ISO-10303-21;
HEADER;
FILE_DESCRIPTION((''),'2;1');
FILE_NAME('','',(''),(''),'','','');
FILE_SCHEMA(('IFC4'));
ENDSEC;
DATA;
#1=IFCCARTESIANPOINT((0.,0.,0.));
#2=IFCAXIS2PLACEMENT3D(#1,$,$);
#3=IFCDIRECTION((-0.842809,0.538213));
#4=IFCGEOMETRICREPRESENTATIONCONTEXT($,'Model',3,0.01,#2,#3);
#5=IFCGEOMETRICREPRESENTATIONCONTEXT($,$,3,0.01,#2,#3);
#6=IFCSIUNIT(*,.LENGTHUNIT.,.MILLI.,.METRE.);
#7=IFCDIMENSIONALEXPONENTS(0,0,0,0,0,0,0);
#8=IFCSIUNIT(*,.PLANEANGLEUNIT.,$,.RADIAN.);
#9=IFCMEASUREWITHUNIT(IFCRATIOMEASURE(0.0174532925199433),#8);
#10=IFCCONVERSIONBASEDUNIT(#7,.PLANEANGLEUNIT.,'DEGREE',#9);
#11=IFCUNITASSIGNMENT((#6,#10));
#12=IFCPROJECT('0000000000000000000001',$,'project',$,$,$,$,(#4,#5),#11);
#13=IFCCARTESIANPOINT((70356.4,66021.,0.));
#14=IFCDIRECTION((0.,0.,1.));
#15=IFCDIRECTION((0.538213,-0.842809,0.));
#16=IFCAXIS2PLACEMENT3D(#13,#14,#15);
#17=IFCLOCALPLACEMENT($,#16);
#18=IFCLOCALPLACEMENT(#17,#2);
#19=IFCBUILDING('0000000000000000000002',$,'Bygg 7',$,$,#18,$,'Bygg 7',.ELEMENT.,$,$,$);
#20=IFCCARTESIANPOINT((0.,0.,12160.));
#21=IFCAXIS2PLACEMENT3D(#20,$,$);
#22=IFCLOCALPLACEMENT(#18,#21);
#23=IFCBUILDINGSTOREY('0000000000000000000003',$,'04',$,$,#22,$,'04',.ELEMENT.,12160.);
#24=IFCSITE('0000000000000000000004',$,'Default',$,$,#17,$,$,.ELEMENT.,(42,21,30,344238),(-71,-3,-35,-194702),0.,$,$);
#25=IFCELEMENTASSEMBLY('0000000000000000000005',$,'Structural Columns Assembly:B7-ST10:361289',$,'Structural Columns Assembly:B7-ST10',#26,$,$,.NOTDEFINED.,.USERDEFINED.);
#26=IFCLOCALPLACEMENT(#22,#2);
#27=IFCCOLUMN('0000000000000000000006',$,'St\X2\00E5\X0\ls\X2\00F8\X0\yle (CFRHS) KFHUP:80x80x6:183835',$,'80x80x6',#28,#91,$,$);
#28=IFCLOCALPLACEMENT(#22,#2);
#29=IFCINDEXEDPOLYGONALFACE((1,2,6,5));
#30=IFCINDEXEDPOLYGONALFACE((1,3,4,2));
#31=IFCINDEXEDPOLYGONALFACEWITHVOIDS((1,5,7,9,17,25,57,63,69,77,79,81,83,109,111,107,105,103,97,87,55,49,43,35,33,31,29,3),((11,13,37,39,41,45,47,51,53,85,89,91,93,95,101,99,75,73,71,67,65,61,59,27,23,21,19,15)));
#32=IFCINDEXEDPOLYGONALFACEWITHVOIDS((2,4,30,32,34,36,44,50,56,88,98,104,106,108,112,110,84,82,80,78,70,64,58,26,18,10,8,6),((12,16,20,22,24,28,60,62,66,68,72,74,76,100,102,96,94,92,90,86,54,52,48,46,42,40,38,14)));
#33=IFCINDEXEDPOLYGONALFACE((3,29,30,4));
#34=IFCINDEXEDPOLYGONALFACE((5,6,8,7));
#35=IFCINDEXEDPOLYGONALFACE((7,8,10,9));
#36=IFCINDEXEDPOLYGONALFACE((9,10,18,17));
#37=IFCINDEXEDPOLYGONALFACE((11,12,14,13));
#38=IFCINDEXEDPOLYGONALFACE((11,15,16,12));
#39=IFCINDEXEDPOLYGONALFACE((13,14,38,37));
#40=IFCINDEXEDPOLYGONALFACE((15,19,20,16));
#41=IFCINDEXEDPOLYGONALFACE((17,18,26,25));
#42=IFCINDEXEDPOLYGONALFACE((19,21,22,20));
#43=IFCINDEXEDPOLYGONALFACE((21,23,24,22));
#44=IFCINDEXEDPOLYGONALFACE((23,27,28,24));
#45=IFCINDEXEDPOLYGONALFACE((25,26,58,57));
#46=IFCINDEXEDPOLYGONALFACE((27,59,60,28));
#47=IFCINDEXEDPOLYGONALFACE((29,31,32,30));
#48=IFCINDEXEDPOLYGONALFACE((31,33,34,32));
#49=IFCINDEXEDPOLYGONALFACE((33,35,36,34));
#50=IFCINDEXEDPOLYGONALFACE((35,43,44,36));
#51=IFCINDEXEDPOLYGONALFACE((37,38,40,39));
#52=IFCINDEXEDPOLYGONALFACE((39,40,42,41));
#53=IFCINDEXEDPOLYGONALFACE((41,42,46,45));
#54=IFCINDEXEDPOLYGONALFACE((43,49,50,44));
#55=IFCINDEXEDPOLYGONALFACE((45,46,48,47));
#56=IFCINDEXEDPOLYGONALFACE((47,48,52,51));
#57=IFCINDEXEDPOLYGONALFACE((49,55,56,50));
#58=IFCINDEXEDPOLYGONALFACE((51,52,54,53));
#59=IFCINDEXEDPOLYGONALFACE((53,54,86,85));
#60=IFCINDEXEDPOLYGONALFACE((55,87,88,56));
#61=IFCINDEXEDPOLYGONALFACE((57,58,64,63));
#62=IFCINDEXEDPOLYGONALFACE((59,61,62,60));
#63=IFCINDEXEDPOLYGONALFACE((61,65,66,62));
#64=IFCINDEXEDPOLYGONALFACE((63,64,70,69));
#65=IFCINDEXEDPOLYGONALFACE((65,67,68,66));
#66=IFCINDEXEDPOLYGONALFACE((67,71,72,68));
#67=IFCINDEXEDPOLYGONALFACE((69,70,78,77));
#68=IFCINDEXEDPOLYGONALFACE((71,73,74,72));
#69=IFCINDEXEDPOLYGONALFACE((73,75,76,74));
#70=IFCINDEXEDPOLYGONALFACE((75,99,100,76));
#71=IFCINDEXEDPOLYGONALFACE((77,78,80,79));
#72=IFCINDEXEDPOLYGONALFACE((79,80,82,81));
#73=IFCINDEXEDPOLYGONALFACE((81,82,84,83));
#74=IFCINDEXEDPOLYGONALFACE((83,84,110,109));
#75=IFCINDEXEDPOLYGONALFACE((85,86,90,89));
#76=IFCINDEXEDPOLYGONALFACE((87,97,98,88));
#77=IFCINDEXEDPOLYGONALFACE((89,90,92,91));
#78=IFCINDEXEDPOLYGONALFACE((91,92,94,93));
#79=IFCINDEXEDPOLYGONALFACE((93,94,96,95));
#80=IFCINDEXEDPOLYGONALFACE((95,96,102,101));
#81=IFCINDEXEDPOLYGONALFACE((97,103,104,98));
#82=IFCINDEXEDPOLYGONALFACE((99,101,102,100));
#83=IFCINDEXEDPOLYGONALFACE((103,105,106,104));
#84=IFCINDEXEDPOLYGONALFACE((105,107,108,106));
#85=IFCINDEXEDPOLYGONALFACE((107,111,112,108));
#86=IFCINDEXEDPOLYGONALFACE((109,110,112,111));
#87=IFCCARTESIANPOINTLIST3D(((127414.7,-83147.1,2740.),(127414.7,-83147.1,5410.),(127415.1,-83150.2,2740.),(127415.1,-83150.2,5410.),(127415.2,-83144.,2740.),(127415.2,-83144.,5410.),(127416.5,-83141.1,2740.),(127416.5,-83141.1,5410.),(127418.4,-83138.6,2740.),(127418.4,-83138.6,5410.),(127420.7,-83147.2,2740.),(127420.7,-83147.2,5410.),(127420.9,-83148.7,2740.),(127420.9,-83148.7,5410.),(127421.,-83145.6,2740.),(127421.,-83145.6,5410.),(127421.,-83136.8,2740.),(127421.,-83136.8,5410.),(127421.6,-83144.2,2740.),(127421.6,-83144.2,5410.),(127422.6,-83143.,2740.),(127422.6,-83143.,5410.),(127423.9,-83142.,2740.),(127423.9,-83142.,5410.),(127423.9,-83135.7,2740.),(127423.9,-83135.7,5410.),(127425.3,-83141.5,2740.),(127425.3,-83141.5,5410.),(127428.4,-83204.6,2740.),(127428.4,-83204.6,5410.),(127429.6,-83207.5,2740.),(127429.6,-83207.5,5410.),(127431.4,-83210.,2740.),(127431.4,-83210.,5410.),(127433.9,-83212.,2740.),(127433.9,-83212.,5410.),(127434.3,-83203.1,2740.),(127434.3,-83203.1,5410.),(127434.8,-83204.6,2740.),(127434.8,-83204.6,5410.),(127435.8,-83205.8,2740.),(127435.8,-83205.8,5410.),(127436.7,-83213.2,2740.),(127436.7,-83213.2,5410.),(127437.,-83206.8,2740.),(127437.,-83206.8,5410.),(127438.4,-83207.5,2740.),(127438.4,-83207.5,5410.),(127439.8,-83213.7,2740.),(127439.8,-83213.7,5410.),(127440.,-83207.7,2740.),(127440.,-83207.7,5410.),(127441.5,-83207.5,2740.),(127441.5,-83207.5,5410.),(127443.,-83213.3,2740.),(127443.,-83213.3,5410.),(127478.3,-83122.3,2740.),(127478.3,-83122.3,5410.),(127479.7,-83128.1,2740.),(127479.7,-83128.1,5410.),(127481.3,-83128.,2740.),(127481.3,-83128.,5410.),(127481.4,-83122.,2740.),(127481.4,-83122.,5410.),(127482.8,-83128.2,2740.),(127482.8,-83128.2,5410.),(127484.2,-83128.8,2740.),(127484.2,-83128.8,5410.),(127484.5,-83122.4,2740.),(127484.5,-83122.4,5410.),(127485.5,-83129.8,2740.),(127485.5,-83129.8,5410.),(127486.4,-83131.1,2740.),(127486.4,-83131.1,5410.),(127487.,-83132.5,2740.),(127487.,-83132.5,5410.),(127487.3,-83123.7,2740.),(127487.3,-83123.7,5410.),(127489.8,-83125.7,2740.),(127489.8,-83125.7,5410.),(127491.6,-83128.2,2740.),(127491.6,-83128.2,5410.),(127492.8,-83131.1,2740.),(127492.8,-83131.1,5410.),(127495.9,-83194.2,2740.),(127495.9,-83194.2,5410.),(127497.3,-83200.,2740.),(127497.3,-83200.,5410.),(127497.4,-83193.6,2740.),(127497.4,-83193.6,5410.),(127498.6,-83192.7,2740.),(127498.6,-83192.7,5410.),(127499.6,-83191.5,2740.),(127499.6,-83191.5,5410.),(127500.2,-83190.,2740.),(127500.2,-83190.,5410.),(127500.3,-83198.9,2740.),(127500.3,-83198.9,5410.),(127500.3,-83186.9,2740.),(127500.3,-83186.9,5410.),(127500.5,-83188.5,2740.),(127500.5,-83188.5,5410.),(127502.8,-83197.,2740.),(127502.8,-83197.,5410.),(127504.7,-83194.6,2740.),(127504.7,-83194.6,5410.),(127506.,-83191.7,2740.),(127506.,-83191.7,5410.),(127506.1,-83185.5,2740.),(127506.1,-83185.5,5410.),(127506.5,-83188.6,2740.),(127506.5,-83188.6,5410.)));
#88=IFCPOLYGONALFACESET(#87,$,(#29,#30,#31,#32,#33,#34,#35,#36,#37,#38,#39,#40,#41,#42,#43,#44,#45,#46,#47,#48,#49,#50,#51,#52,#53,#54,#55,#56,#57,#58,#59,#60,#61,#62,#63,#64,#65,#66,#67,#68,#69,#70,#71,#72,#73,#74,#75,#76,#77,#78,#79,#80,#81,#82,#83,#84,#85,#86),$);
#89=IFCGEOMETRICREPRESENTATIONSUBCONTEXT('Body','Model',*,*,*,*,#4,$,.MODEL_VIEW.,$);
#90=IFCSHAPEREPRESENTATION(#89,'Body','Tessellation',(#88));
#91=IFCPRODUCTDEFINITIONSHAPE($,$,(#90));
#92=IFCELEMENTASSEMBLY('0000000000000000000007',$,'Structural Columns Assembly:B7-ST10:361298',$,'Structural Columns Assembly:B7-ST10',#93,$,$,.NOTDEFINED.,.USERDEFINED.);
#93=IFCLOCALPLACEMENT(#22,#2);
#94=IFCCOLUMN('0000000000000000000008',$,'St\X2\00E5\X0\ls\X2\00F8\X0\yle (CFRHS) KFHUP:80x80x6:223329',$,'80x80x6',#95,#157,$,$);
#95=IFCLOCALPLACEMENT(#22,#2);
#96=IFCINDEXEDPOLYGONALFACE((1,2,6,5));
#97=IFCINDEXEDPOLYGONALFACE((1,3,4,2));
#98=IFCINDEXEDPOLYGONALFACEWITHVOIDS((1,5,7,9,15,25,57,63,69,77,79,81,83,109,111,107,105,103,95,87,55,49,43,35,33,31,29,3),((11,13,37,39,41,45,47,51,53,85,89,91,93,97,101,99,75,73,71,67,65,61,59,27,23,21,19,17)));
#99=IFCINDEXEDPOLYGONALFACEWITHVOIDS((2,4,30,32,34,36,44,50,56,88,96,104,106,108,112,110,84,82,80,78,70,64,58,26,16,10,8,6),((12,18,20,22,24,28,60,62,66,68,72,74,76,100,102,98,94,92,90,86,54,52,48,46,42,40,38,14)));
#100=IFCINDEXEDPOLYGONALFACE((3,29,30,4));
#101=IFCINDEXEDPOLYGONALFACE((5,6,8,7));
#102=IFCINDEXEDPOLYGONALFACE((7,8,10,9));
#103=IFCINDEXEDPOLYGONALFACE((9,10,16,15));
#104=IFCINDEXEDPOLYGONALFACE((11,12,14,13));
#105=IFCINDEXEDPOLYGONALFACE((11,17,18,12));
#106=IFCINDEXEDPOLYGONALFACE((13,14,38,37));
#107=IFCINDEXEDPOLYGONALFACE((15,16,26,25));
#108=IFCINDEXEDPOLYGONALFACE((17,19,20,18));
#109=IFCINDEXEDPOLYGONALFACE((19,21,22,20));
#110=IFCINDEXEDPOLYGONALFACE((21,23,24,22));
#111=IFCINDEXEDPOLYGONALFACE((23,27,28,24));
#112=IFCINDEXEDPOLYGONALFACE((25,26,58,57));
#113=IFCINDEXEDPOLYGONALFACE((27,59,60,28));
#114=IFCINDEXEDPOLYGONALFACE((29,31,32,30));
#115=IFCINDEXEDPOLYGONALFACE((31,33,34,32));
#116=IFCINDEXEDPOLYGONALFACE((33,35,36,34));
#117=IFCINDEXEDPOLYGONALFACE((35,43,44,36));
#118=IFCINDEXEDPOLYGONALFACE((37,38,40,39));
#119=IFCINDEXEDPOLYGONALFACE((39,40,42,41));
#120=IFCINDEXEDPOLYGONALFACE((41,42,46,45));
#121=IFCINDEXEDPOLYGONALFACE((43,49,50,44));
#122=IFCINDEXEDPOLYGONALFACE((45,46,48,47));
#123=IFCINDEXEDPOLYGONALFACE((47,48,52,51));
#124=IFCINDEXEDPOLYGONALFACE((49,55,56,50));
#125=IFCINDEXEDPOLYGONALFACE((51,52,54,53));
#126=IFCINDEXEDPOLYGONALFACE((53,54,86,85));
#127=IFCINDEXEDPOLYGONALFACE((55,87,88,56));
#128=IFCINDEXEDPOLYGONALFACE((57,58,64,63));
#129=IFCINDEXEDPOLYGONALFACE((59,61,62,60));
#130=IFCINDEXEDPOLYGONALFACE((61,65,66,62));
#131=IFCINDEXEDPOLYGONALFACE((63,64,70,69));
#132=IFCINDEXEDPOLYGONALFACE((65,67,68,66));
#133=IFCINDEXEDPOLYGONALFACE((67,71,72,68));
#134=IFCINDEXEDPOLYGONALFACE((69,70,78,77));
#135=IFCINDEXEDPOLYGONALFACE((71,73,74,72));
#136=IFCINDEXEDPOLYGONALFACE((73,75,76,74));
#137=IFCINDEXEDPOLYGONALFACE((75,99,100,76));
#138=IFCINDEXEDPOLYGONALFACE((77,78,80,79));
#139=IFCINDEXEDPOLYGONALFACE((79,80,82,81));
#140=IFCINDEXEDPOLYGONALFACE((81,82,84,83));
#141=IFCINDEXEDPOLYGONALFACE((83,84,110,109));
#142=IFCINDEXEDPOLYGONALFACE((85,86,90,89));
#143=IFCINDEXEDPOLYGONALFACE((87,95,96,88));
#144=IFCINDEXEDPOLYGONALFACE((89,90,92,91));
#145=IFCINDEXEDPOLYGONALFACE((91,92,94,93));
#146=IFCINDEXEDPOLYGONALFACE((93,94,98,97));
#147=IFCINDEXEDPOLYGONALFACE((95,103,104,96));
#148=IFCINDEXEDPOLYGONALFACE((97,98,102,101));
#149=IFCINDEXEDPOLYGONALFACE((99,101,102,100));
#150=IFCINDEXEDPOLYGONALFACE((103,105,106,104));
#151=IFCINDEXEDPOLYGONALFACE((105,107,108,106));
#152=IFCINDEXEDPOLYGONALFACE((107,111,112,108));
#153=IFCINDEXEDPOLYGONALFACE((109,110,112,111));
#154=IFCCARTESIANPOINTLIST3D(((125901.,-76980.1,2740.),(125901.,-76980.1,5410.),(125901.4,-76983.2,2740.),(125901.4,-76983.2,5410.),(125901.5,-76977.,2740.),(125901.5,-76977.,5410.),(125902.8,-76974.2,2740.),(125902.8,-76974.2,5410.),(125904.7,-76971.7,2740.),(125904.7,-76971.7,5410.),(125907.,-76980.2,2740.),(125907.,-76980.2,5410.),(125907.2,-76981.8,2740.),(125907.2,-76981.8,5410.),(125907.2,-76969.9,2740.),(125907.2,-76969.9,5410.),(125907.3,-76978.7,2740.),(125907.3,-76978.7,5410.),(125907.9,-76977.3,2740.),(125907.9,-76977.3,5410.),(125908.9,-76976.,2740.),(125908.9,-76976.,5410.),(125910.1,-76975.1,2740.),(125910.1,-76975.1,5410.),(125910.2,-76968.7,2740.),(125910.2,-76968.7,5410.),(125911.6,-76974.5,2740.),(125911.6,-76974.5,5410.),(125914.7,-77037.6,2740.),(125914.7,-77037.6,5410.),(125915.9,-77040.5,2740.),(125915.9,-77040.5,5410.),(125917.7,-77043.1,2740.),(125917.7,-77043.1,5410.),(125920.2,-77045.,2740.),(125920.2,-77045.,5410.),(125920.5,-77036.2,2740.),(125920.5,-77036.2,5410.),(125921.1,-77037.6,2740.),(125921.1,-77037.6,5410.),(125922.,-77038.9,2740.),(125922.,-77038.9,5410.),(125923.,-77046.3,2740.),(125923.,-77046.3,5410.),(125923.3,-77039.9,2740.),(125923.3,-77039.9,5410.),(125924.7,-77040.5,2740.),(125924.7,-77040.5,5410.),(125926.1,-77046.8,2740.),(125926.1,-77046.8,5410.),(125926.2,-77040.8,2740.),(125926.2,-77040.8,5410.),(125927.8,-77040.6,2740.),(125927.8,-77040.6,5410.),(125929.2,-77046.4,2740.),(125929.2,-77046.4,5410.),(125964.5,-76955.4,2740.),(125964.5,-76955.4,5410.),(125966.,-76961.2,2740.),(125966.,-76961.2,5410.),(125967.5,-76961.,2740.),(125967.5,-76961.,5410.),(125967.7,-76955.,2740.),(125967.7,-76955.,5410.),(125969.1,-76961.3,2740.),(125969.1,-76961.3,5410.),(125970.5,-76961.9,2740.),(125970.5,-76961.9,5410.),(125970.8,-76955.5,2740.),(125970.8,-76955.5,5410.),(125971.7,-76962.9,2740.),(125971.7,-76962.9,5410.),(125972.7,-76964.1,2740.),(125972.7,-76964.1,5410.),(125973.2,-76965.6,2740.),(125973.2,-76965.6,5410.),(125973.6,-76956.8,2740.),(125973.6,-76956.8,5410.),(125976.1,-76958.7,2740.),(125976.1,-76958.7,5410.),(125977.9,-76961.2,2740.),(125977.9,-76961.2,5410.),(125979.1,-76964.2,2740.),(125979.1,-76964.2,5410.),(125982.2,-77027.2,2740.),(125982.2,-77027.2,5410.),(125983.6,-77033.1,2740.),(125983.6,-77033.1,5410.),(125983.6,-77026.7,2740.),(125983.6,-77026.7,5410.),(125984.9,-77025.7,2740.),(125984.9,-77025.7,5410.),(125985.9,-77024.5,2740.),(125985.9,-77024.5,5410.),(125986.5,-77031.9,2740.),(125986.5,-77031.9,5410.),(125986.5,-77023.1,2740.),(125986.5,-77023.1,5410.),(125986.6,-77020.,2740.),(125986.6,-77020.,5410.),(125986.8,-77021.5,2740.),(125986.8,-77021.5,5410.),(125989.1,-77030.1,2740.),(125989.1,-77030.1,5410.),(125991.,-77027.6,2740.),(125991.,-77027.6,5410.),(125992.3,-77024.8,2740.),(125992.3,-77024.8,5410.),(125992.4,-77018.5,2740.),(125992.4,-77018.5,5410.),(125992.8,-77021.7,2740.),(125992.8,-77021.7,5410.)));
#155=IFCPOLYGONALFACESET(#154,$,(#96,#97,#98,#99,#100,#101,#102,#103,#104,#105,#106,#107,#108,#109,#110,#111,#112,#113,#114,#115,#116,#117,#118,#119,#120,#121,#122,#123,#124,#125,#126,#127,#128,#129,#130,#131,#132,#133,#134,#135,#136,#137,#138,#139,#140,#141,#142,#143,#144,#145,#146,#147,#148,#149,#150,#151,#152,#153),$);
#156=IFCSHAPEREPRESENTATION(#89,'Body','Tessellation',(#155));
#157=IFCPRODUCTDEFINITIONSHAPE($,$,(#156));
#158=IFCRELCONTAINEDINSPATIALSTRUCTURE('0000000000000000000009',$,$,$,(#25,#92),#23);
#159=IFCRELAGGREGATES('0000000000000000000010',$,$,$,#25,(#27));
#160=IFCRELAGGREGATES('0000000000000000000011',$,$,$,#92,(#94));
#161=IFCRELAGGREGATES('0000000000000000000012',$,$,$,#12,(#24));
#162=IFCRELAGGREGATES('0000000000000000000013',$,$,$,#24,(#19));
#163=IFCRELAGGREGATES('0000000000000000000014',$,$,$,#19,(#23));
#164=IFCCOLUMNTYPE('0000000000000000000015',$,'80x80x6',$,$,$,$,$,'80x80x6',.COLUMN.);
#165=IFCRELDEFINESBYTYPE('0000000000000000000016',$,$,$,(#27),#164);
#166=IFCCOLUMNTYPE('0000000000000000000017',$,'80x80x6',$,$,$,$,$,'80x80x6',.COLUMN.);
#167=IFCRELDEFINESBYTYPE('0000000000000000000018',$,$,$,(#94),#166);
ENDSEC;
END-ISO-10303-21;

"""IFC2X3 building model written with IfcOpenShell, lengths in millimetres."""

from ifc_helpers import new_model, entity, si_unit, converted_unit, direction, frame, frame_2d, origin, place, context, subcontext, project, spatial, polyline, circle_curve, parameter, trimmed, segment, composite_curve, outline, extrude, source, transform, mapped, type_object, type_shapes, element, aggregate, save


model = new_model("IFC2X3")

# Units and contexts
model_context = context("Model", 3, precision=0.01, world=origin(), true_north=direction((-0.842809, 0.538213)))
context_of_model = context(None, 3, precision=0.01, world=origin(), true_north=direction((-0.842809, 0.538213)))
body_context = subcontext(model_context, "Body", "Model", "MODEL_VIEW")
ifc_project = project(units=[si_unit("LENGTHUNIT", "METRE", prefix="MILLI"), converted_unit("PLANEANGLEUNIT", "DEGREE", entity("IfcRatioMeasure", 0.0174532925199433), si_unit("PLANEANGLEUNIT", "RADIAN"), dimensions=[0, 0, 0, 0, 0, 0, 0])], contexts=[model_context, context_of_model])

# Site, building, storey
site_placement = place(None, frame((70356.4, 66021.0, 0.0), z_axis=(0.0, 0.0, 1.0), x_axis=(0.538213, -0.842809, 0.0)))
site = spatial("IfcSite", under=ifc_project, at=site_placement, Name="Default", CompositionType="ELEMENT", RefLatitude=(42, 21, 30, 344238), RefLongitude=(-71, -3, -35, -194702), RefElevation=0.0)
building_placement = place(site_placement, origin())
building = spatial("IfcBuilding", under=site, at=building_placement, Name="Bygg 7", LongName="Bygg 7", CompositionType="ELEMENT")
storey_placement = place(building_placement, frame((0.0, 0.0, 12160.0)))
storey = spatial("IfcBuildingStorey", under=building, at=storey_placement, Name="04", LongName="04", CompositionType="ELEMENT", Elevation=12160.0)

# Element assemblies, columns
assembly_1_placement = place(storey_placement, origin())
assembly_1 = element("IfcElementAssembly", 1, at=assembly_1_placement, inside=storey, Name="Structural Columns Assembly:B7-ST10:361289", ObjectType="Structural Columns Assembly:B7-ST10", AssemblyPlace="NOTDEFINED", PredefinedType="USERDEFINED")
column_type_1 = type_object("IfcColumnType", Name="80x80x6", ElementType="80x80x6", PredefinedType="COLUMN")
shared_shape_1 = source(origin(), body_context, "Body", "SweptSolid", [
    extrude(outline(composite_curve([segment(trimmed(circle_curve(frame_2d((-28.0, 28.0), x_axis=(1.0, 0.0)), 12.0), [parameter(90.0)], [parameter(180.0)], True, "PARAMETER"), True, "CONTINUOUS"), segment(polyline([(-40.0, 28.0), (-40.0, -28.0)]), True, "CONTINUOUS"), segment(trimmed(circle_curve(frame_2d((-28.0, -28.0), x_axis=(1.0, 0.0)), 12.0), [parameter(180.0)], [parameter(270.0)], True, "PARAMETER"), True, "CONTINUOUS"), segment(polyline([(-28.0, -40.0), (28.0, -40.0)]), True, "CONTINUOUS"), segment(trimmed(circle_curve(frame_2d((28.0, -28.0), x_axis=(1.0, 0.0)), 12.0), [parameter(270.0)], [parameter(0.0)], True, "PARAMETER"), True, "CONTINUOUS"), segment(polyline([(40.0, -28.0), (40.0, 28.0)]), True, "CONTINUOUS"), segment(trimmed(circle_curve(frame_2d((28.0, 28.0), x_axis=(1.0, 0.0)), 12.0), [parameter(0.0)], [parameter(90.0)], True, "PARAMETER"), True, "CONTINUOUS"), segment(polyline([(28.0, 40.0), (-28.0, 40.0)]), True, "CONTINUOUS")], self_intersect=False), holes=[composite_curve([segment(polyline([(-28.0, 34.0), (28.0, 34.0)]), True, "CONTINUOUS"), segment(trimmed(circle_curve(frame_2d((28.0, 28.0), x_axis=(1.0, 0.0)), 6.0), [parameter(360.0)], [parameter(90.0)], True, "PARAMETER"), False, "CONTINUOUS"), segment(polyline([(34.0, 28.0), (34.0, -28.0)]), True, "CONTINUOUS"), segment(trimmed(circle_curve(frame_2d((28.0, -28.0), x_axis=(1.0, 0.0)), 6.0), [parameter(270.0)], [parameter(360.0)], True, "PARAMETER"), False, "CONTINUOUS"), segment(polyline([(28.0, -34.0), (-28.0, -34.0)]), True, "CONTINUOUS"), segment(trimmed(circle_curve(frame_2d((-28.0, -28.0), x_axis=(1.0, 0.0)), 6.0), [parameter(180.0)], [parameter(270.0)], True, "PARAMETER"), False, "CONTINUOUS"), segment(polyline([(-34.0, -28.0), (-34.0, 28.0)]), True, "CONTINUOUS"), segment(trimmed(circle_curve(frame_2d((-28.0, 28.0), x_axis=(1.0, 0.0)), 6.0), [parameter(90.0)], [parameter(180.0)], True, "PARAMETER"), False, "CONTINUOUS")], self_intersect=False)]), frame((47.5, 47.5, 0.0), z_axis=(0.0, 0.0, 1.0), x_axis=(-0.971172, -0.238381, 0.0)), (0.0, 0.0, 1.0), 2670.0),
])
type_shapes(column_type_1, [shared_shape_1])
column_1_placement = place(assembly_1_placement, frame((127413.1, -83215.3, 2740.0)))
column_1 = element("IfcColumn", 2, at=column_1_placement, type_object=column_type_1, Name="Stålsøyle (CFRHS) KFHUP:80x80x6:183835", ObjectType="80x80x6", context=body_context, shape_type="MappedRepresentation", body=[
    mapped(shared_shape_1, transform((0.0, 0.0, 0.0), scale=1.0)),
])
aggregate(assembly_1, [column_1])
assembly_2_placement = place(storey_placement, origin())
assembly_2 = element("IfcElementAssembly", 3, at=assembly_2_placement, inside=storey, Name="Structural Columns Assembly:B7-ST10:361298", ObjectType="Structural Columns Assembly:B7-ST10", AssemblyPlace="NOTDEFINED", PredefinedType="USERDEFINED")
column_type_2 = type_object("IfcColumnType", Name="80x80x6", ElementType="80x80x6", PredefinedType="COLUMN")
shared_shape_2 = source(origin(), body_context, "Body", "SweptSolid", [
    extrude(outline(composite_curve([segment(trimmed(circle_curve(frame_2d((-28.0, 28.0), x_axis=(1.0, 0.0)), 12.0), [parameter(90.0)], [parameter(180.0)], True, "PARAMETER"), True, "CONTINUOUS"), segment(polyline([(-40.0, 28.0), (-40.0, -28.0)]), True, "CONTINUOUS"), segment(trimmed(circle_curve(frame_2d((-28.0, -28.0), x_axis=(1.0, 0.0)), 12.0), [parameter(180.0)], [parameter(270.0)], True, "PARAMETER"), True, "CONTINUOUS"), segment(polyline([(-28.0, -40.0), (28.0, -40.0)]), True, "CONTINUOUS"), segment(trimmed(circle_curve(frame_2d((28.0, -28.0), x_axis=(1.0, 0.0)), 12.0), [parameter(270.0)], [parameter(0.0)], True, "PARAMETER"), True, "CONTINUOUS"), segment(polyline([(40.0, -28.0), (40.0, 28.0)]), True, "CONTINUOUS"), segment(trimmed(circle_curve(frame_2d((28.0, 28.0), x_axis=(1.0, 0.0)), 12.0), [parameter(0.0)], [parameter(90.0)], True, "PARAMETER"), True, "CONTINUOUS"), segment(polyline([(28.0, 40.0), (-28.0, 40.0)]), True, "CONTINUOUS")], self_intersect=False), holes=[composite_curve([segment(polyline([(-28.0, 34.0), (28.0, 34.0)]), True, "CONTINUOUS"), segment(trimmed(circle_curve(frame_2d((28.0, 28.0), x_axis=(1.0, 0.0)), 6.0), [parameter(360.0)], [parameter(90.0)], True, "PARAMETER"), False, "CONTINUOUS"), segment(polyline([(34.0, 28.0), (34.0, -28.0)]), True, "CONTINUOUS"), segment(trimmed(circle_curve(frame_2d((28.0, -28.0), x_axis=(1.0, 0.0)), 6.0), [parameter(270.0)], [parameter(360.0)], True, "PARAMETER"), False, "CONTINUOUS"), segment(polyline([(28.0, -34.0), (-28.0, -34.0)]), True, "CONTINUOUS"), segment(trimmed(circle_curve(frame_2d((-28.0, -28.0), x_axis=(1.0, 0.0)), 6.0), [parameter(180.0)], [parameter(270.0)], True, "PARAMETER"), False, "CONTINUOUS"), segment(polyline([(-34.0, -28.0), (-34.0, 28.0)]), True, "CONTINUOUS"), segment(trimmed(circle_curve(frame_2d((-28.0, 28.0), x_axis=(1.0, 0.0)), 6.0), [parameter(90.0)], [parameter(180.0)], True, "PARAMETER"), False, "CONTINUOUS")], self_intersect=False)]), frame((47.5, 47.5, 0.0), z_axis=(0.0, 0.0, 1.0), x_axis=(-0.971172, -0.238381, 0.0)), (0.0, 0.0, 1.0), 2670.0),
])
type_shapes(column_type_2, [shared_shape_2])
column_2_placement = place(assembly_2_placement, frame((125899.4, -77048.3, 2740.0)))
column_2 = element("IfcColumn", 4, at=column_2_placement, type_object=column_type_2, Name="Stålsøyle (CFRHS) KFHUP:80x80x6:223329", ObjectType="80x80x6", context=body_context, shape_type="MappedRepresentation", body=[
    mapped(shared_shape_2, transform((0.0, 0.0, 0.0), scale=1.0)),
])
aggregate(assembly_2, [column_2])

save(model, "model.ifc")
